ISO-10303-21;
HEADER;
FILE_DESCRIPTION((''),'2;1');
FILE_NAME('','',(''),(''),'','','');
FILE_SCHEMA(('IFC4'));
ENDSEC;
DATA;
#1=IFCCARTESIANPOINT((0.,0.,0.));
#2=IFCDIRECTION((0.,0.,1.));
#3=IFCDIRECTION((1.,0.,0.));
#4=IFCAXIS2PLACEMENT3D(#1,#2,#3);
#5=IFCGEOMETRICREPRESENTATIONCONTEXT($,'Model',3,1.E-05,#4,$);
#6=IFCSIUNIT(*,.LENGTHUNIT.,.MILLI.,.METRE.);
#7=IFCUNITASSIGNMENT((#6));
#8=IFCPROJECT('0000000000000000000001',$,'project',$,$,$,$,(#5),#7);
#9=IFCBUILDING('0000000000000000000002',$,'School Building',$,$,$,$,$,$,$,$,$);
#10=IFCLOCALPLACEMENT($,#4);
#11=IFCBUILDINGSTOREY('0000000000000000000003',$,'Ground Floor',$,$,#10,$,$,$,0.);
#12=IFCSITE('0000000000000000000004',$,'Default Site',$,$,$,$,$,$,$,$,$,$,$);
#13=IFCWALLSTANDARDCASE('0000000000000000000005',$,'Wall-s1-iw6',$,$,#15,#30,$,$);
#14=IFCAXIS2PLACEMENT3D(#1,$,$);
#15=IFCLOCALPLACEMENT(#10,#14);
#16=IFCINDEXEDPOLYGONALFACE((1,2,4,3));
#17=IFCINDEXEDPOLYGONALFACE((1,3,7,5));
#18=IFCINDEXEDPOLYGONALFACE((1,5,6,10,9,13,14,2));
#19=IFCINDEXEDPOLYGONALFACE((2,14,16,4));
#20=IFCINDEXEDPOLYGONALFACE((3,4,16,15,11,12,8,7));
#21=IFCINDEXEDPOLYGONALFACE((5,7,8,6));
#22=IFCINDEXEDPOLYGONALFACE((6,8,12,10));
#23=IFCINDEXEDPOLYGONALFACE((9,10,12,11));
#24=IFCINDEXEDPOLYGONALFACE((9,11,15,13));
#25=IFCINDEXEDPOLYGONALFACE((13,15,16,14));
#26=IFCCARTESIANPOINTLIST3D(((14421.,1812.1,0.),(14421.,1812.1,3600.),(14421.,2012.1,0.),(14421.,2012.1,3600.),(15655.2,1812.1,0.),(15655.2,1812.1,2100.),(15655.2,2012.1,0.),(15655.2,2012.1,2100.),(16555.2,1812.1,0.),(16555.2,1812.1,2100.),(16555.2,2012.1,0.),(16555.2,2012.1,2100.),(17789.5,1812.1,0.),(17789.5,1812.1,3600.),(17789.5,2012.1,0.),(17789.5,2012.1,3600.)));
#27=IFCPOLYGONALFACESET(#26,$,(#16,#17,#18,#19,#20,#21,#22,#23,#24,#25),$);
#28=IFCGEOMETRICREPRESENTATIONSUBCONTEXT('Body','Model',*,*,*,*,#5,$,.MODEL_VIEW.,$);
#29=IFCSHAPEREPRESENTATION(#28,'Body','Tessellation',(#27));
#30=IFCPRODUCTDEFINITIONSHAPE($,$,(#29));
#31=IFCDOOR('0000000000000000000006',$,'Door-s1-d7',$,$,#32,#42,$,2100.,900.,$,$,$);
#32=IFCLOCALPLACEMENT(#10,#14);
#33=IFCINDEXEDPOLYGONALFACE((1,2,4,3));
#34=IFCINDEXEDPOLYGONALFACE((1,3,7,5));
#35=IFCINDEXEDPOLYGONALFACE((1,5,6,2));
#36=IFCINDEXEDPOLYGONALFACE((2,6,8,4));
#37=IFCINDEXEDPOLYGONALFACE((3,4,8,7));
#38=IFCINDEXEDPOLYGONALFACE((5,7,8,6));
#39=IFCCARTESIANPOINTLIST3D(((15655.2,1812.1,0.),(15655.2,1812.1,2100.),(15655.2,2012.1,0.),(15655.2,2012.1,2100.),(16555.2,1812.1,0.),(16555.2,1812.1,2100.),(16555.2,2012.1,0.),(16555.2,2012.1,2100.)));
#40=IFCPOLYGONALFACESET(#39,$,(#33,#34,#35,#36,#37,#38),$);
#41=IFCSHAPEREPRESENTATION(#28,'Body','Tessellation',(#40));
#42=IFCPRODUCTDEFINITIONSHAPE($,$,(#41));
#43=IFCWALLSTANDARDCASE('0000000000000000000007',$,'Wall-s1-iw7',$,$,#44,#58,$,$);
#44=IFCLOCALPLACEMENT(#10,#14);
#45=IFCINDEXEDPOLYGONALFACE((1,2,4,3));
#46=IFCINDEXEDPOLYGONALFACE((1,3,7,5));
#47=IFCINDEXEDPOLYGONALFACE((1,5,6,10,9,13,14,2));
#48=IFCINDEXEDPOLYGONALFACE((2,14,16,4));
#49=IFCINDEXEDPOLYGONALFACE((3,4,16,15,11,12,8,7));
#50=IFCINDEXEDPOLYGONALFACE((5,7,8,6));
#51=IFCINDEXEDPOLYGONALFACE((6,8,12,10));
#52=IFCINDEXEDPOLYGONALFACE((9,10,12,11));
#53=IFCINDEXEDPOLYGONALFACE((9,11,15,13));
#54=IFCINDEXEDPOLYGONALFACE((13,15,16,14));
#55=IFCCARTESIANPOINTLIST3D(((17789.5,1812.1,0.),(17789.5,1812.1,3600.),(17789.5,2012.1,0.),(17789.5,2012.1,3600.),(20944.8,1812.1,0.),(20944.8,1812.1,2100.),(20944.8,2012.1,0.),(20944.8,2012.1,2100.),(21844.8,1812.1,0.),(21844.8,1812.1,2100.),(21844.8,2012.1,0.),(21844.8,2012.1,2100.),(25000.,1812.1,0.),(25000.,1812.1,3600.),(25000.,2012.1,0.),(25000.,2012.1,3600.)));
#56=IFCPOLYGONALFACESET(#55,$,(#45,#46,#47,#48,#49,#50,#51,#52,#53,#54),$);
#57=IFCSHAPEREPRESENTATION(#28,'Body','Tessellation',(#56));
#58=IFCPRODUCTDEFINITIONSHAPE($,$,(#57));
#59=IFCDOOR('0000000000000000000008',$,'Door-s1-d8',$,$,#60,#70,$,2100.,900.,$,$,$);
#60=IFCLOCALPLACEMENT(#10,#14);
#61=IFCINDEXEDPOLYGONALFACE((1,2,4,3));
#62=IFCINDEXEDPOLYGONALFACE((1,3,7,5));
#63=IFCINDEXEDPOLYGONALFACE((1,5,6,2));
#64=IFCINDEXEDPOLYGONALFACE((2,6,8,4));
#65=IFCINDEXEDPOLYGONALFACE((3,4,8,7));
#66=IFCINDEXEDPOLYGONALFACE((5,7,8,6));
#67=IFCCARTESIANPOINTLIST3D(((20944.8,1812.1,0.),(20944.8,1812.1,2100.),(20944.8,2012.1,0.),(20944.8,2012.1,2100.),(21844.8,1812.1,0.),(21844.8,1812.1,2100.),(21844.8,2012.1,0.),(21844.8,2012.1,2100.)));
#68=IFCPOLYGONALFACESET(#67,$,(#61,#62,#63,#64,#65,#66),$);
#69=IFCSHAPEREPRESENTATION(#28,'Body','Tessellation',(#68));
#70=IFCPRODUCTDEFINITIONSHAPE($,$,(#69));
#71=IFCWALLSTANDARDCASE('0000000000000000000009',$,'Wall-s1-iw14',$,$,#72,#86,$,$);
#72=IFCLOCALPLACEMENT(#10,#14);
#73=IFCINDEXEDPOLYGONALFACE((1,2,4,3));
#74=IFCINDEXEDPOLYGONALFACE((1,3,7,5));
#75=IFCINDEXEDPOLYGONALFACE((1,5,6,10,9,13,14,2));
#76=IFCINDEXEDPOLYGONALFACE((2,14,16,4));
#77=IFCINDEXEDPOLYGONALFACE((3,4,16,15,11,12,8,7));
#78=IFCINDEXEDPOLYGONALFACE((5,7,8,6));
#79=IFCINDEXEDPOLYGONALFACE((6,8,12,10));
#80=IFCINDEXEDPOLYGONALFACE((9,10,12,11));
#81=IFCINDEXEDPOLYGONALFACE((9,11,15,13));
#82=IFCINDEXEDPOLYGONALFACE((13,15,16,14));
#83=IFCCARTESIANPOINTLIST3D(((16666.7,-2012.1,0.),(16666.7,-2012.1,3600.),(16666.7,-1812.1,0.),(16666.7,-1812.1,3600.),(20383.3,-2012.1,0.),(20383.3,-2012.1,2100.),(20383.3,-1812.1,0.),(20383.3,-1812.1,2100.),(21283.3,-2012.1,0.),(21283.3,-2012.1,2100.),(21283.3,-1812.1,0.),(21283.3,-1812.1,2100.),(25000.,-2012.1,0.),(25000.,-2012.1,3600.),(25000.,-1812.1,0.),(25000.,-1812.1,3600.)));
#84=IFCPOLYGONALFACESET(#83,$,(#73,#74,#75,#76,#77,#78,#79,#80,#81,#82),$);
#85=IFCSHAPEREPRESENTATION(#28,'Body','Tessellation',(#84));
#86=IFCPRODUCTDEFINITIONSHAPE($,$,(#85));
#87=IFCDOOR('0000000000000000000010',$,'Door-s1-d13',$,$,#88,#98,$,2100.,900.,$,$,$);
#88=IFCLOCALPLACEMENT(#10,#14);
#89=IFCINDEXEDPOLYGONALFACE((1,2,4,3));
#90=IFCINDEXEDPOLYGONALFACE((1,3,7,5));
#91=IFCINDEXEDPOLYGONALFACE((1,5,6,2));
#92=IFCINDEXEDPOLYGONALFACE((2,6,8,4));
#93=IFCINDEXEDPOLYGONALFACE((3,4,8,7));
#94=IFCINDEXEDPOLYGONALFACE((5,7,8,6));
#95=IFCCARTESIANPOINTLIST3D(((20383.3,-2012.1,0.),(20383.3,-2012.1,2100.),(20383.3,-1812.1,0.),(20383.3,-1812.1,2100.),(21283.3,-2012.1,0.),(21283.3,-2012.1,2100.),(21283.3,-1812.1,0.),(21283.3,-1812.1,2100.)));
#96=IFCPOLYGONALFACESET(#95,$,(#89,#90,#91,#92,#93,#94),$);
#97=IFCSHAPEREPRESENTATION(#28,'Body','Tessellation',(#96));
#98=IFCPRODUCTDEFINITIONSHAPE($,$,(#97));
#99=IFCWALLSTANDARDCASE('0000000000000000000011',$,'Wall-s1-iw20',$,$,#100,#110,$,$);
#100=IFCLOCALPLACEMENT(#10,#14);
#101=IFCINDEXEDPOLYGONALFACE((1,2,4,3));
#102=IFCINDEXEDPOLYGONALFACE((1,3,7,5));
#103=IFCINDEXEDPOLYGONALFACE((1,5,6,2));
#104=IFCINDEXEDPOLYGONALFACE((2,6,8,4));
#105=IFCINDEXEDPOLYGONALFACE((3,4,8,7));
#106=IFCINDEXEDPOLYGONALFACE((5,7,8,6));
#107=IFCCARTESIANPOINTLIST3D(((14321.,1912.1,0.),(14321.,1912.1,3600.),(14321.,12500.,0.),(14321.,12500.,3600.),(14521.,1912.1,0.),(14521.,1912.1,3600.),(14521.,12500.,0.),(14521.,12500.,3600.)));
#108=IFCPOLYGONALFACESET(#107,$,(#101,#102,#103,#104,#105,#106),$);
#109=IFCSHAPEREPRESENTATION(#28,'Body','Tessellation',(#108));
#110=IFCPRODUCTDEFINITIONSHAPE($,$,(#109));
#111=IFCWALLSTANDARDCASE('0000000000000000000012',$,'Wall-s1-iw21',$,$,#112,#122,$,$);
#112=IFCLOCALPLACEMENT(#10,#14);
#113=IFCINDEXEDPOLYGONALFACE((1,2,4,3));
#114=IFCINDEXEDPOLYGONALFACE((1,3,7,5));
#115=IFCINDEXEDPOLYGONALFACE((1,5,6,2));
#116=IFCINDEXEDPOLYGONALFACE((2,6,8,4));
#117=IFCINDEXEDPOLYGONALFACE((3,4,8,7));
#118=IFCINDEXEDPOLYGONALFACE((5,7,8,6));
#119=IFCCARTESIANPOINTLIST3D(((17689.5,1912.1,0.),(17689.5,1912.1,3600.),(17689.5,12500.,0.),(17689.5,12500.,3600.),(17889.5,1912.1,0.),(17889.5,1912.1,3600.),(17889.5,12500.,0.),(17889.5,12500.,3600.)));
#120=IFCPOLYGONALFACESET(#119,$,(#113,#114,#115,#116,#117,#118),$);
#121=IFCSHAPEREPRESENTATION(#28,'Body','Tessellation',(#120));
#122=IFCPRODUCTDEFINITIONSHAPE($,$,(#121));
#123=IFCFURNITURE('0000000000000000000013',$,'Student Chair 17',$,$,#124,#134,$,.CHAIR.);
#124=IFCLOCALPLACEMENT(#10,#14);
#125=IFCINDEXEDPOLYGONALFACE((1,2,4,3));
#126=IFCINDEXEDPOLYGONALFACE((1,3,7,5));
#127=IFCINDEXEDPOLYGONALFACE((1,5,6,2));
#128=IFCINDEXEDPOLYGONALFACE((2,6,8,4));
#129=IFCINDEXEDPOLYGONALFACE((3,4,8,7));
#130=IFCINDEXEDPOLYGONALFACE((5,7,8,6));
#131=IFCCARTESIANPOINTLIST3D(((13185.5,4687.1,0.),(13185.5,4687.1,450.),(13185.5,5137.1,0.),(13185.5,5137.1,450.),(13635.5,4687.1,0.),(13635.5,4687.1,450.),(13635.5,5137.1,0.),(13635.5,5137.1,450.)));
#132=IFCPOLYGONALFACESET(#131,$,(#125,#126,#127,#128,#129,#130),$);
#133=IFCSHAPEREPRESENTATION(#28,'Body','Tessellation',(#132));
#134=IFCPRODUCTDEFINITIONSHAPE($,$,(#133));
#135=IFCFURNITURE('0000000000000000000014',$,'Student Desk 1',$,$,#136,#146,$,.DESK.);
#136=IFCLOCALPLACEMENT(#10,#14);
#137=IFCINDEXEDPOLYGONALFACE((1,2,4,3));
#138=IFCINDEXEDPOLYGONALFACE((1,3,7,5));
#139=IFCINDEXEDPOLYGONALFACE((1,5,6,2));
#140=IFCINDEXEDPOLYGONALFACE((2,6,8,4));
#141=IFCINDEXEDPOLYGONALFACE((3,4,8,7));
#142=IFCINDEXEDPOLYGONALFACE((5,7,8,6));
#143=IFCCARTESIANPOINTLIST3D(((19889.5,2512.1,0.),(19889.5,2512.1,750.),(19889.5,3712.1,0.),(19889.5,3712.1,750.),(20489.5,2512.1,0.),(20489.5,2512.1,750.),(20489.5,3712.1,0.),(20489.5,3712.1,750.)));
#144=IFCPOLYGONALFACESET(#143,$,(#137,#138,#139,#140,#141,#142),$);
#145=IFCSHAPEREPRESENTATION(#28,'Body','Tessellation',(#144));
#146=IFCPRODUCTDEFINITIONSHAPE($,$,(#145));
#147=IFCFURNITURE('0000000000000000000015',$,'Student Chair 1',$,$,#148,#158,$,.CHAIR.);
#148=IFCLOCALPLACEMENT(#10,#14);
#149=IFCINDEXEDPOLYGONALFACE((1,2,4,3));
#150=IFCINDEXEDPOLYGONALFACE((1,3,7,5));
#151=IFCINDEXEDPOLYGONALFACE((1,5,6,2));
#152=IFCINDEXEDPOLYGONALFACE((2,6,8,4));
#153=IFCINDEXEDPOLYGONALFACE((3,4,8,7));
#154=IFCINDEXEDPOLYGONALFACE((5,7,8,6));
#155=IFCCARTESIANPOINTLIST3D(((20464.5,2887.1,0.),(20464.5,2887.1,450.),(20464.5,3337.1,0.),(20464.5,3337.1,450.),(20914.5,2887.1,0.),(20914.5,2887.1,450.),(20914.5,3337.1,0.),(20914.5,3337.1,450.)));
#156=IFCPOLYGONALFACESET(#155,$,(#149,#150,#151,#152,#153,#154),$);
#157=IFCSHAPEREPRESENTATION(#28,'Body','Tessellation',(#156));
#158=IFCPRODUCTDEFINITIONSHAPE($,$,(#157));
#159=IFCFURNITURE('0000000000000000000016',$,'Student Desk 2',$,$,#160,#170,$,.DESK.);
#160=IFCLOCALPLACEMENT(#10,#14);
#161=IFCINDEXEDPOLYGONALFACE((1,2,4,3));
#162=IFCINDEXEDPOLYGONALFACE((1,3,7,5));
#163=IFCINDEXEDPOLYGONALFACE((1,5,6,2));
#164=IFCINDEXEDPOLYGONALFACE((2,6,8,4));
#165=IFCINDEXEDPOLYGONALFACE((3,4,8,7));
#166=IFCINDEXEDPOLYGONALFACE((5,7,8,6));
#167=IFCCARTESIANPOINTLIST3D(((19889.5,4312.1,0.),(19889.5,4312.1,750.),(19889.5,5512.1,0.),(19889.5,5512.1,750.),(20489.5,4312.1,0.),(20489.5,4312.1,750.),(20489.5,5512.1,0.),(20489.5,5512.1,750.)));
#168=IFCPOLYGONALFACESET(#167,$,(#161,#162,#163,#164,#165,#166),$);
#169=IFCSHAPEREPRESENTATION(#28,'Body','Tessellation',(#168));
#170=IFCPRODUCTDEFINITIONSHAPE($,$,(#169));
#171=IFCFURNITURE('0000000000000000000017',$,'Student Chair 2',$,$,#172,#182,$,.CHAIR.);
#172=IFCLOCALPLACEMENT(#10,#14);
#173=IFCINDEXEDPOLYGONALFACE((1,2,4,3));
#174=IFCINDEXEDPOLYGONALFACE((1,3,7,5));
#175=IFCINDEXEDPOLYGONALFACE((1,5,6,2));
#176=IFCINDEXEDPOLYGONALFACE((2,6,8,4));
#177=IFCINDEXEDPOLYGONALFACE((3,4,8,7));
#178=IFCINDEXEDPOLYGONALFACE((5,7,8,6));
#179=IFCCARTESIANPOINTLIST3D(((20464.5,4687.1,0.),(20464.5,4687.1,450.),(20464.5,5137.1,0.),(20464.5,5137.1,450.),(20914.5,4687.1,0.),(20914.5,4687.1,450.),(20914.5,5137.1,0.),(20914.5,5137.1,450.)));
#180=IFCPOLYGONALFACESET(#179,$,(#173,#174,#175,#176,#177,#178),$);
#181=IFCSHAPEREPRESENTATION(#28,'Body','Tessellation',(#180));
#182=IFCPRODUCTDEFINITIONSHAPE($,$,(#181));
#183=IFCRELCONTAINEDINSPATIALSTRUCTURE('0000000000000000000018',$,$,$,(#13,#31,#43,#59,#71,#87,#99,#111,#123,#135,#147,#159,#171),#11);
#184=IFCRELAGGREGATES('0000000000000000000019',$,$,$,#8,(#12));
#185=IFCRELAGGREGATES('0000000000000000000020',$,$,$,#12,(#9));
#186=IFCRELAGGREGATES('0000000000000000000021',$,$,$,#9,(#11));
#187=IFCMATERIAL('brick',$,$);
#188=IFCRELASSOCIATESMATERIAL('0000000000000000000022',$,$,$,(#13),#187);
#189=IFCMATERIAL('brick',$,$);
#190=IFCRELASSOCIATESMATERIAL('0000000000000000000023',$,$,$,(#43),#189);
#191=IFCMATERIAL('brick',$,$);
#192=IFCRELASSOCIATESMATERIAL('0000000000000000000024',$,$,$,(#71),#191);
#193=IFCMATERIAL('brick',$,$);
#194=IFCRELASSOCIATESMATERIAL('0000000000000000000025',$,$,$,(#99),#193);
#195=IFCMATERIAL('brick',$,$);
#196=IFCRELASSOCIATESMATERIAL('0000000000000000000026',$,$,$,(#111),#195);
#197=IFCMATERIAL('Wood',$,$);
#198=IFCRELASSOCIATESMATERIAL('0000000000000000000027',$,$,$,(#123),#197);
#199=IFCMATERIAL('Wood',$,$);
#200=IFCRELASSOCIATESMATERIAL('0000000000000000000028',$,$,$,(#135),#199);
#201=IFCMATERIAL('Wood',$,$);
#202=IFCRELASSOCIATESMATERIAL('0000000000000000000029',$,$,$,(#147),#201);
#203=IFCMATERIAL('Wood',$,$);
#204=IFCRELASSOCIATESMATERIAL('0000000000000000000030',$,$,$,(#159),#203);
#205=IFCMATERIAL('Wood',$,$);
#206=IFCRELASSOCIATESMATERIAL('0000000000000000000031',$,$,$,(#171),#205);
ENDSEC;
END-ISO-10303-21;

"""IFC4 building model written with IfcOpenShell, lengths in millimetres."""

from ifc_helpers import new_model, si_unit, frame, frame_2d, origin_with_axes, origin_2d, place, context, subcontext, project, spatial, rectangle, extrude, material, element, fill, save


model = new_model("IFC4")

# Units and contexts
model_context = context("Model", 3, precision=1e-05, world=origin_with_axes())
body_context = subcontext(model_context, "Body", "Model", "MODEL_VIEW")
ifc_project = project(units=[si_unit("LENGTHUNIT", "METRE", prefix="MILLI")], contexts=[model_context])

# Site, building, storey
site = spatial("IfcSite", under=ifc_project, Name="Default Site")
building = spatial("IfcBuilding", under=site, Name="School Building")
storey_placement = place(None, origin_with_axes())
storey = spatial("IfcBuildingStorey", under=building, at=storey_placement, Name="Ground Floor", Elevation=0.0)

# Walls, openings, doors
ifc_material_1 = material(Name="brick")
wall_1_placement = place(storey_placement, frame((14421.0, 1912.1, 0.0), z_axis=(0.0, 0.0, 1.0), x_axis=(1.0, 0.0, 0.0)))
wall_1 = element("IfcWallStandardCase", 1, at=wall_1_placement, inside=storey, material=ifc_material_1, Name="Wall-s1-iw6", context=body_context, shape_type="SweptSolid", body=[
    extrude(rectangle(XDim=3368.6, YDim=200.0, at=frame_2d((1684.3, 0.0))), origin_with_axes(), (0.0, 0.0, 1.0), 3600.0),
])
opening_1_placement = place(wall_1_placement, frame((1234.3, 0.0, 0.0), z_axis=(0.0, 0.0, 1.0), x_axis=(1.0, 0.0, 0.0)))
opening_1 = element("IfcOpeningElement", 2, at=opening_1_placement, cuts=wall_1, context=body_context, shape_type="SweptSolid", body=[
    extrude(rectangle(XDim=900.0, YDim=400.0, at=frame_2d((450.0, 0.0))), origin_with_axes(), (0.0, 0.0, 1.0), 2100.0),
])
door_1_placement = place(storey_placement, frame((15655.2, 1912.1, 0.0), z_axis=(0.0, 0.0, 1.0), x_axis=(1.0, 0.0, 0.0)))
door_1 = element("IfcDoor", 3, at=door_1_placement, inside=storey, Name="Door-s1-d7", OverallHeight=2100.0, OverallWidth=900.0, context=body_context, shape_type="SweptSolid", body=[
    extrude(rectangle(XDim=900.0, YDim=200.0, at=frame_2d((450.0, 0.0))), origin_with_axes(), (0.0, 0.0, 1.0), 2100.0),
])
fill(opening_1, door_1)
ifc_material_2 = material(Name="brick")
wall_2_placement = place(storey_placement, frame((17789.5, 1912.1, 0.0), z_axis=(0.0, 0.0, 1.0), x_axis=(1.0, 0.0, 0.0)))
wall_2 = element("IfcWallStandardCase", 4, at=wall_2_placement, inside=storey, material=ifc_material_2, Name="Wall-s1-iw7", context=body_context, shape_type="SweptSolid", body=[
    extrude(rectangle(XDim=7210.5, YDim=200.0, at=frame_2d((3605.2, 0.0))), origin_with_axes(), (0.0, 0.0, 1.0), 3600.0),
])
opening_2_placement = place(wall_2_placement, frame((3155.2, 0.0, 0.0), z_axis=(0.0, 0.0, 1.0), x_axis=(1.0, 0.0, 0.0)))
opening_2 = element("IfcOpeningElement", 5, at=opening_2_placement, cuts=wall_2, context=body_context, shape_type="SweptSolid", body=[
    extrude(rectangle(XDim=900.0, YDim=400.0, at=frame_2d((450.0, 0.0))), origin_with_axes(), (0.0, 0.0, 1.0), 2100.0),
])
door_2_placement = place(storey_placement, frame((20944.8, 1912.1, 0.0), z_axis=(0.0, 0.0, 1.0), x_axis=(1.0, 0.0, 0.0)))
door_2 = element("IfcDoor", 6, at=door_2_placement, inside=storey, Name="Door-s1-d8", OverallHeight=2100.0, OverallWidth=900.0, context=body_context, shape_type="SweptSolid", body=[
    extrude(rectangle(XDim=900.0, YDim=200.0, at=frame_2d((450.0, 0.0))), origin_with_axes(), (0.0, 0.0, 1.0), 2100.0),
])
fill(opening_2, door_2)
ifc_material_3 = material(Name="brick")
wall_3_placement = place(storey_placement, frame((16666.7, -1912.1, 0.0), z_axis=(0.0, 0.0, 1.0), x_axis=(1.0, 0.0, 0.0)))
wall_3 = element("IfcWallStandardCase", 7, at=wall_3_placement, inside=storey, material=ifc_material_3, Name="Wall-s1-iw14", context=body_context, shape_type="SweptSolid", body=[
    extrude(rectangle(XDim=8333.3, YDim=200.0, at=frame_2d((4166.7, 0.0))), origin_with_axes(), (0.0, 0.0, 1.0), 3600.0),
])
opening_3_placement = place(wall_3_placement, frame((3716.7, 0.0, 0.0), z_axis=(0.0, 0.0, 1.0), x_axis=(1.0, 0.0, 0.0)))
opening_3 = element("IfcOpeningElement", 8, at=opening_3_placement, cuts=wall_3, context=body_context, shape_type="SweptSolid", body=[
    extrude(rectangle(XDim=900.0, YDim=400.0, at=frame_2d((450.0, 0.0))), origin_with_axes(), (0.0, 0.0, 1.0), 2100.0),
])
door_3_placement = place(storey_placement, frame((20383.3, -1912.1, 0.0), z_axis=(0.0, 0.0, 1.0), x_axis=(1.0, 0.0, 0.0)))
door_3 = element("IfcDoor", 9, at=door_3_placement, inside=storey, Name="Door-s1-d13", OverallHeight=2100.0, OverallWidth=900.0, context=body_context, shape_type="SweptSolid", body=[
    extrude(rectangle(XDim=900.0, YDim=200.0, at=frame_2d((450.0, 0.0))), origin_with_axes(), (0.0, 0.0, 1.0), 2100.0),
])
fill(opening_3, door_3)

# Walls
ifc_material_4 = material(Name="brick")
wall_4_placement = place(storey_placement, frame((14421.0, 1912.1, 0.0), z_axis=(0.0, 0.0, 1.0), x_axis=(0.0, 1.0, 0.0)))
element("IfcWallStandardCase", 10, at=wall_4_placement, inside=storey, material=ifc_material_4, Name="Wall-s1-iw20", context=body_context, shape_type="SweptSolid", body=[
    extrude(rectangle(XDim=10587.9, YDim=200.0, at=frame_2d((5293.9, 0.0))), origin_with_axes(), (0.0, 0.0, 1.0), 3600.0),
])
ifc_material_5 = material(Name="brick")
wall_5_placement = place(storey_placement, frame((17789.5, 1912.1, 0.0), z_axis=(0.0, 0.0, 1.0), x_axis=(0.0, 1.0, 0.0)))
element("IfcWallStandardCase", 11, at=wall_5_placement, inside=storey, material=ifc_material_5, Name="Wall-s1-iw21", context=body_context, shape_type="SweptSolid", body=[
    extrude(rectangle(XDim=10587.9, YDim=200.0, at=frame_2d((5293.9, 0.0))), origin_with_axes(), (0.0, 0.0, 1.0), 3600.0),
])

# Furniture
ifc_material_6 = material(Name="Wood")
furniture_1_placement = place(storey_placement, frame((13410.5, 4912.1, 0.0), z_axis=(0.0, 0.0, 1.0), x_axis=(1.0, 0.0, 0.0)))
element("IfcFurniture", 12, at=furniture_1_placement, inside=storey, material=ifc_material_6, Name="Student Chair 17", PredefinedType="CHAIR", context=body_context, shape_type="SweptSolid", body=[
    extrude(rectangle(XDim=450.0, YDim=450.0, at=origin_2d()), origin_with_axes(), (0.0, 0.0, 1.0), 450.0),
])
ifc_material_7 = material(Name="Wood")
furniture_2_placement = place(storey_placement, frame((20189.5, 3112.1, 0.0), z_axis=(0.0, 0.0, 1.0), x_axis=(0.0, 1.0, 0.0)))
element("IfcFurniture", 13, at=furniture_2_placement, inside=storey, material=ifc_material_7, Name="Student Desk 1", PredefinedType="DESK", context=body_context, shape_type="SweptSolid", body=[
    extrude(rectangle(XDim=1200.0, YDim=600.0, at=origin_2d()), origin_with_axes(), (0.0, 0.0, 1.0), 750.0),
])
ifc_material_8 = material(Name="Wood")
furniture_3_placement = place(storey_placement, frame((20689.5, 3112.1, 0.0), z_axis=(0.0, 0.0, 1.0), x_axis=(1.0, 0.0, 0.0)))
element("IfcFurniture", 14, at=furniture_3_placement, inside=storey, material=ifc_material_8, Name="Student Chair 1", PredefinedType="CHAIR", context=body_context, shape_type="SweptSolid", body=[
    extrude(rectangle(XDim=450.0, YDim=450.0, at=origin_2d()), origin_with_axes(), (0.0, 0.0, 1.0), 450.0),
])
ifc_material_9 = material(Name="Wood")
furniture_4_placement = place(storey_placement, frame((20189.5, 4912.1, 0.0), z_axis=(0.0, 0.0, 1.0), x_axis=(0.0, 1.0, 0.0)))
element("IfcFurniture", 15, at=furniture_4_placement, inside=storey, material=ifc_material_9, Name="Student Desk 2", PredefinedType="DESK", context=body_context, shape_type="SweptSolid", body=[
    extrude(rectangle(XDim=1200.0, YDim=600.0, at=origin_2d()), origin_with_axes(), (0.0, 0.0, 1.0), 750.0),
])
ifc_material_10 = material(Name="Wood")
furniture_5_placement = place(storey_placement, frame((20689.5, 4912.1, 0.0), z_axis=(0.0, 0.0, 1.0), x_axis=(1.0, 0.0, 0.0)))
element("IfcFurniture", 16, at=furniture_5_placement, inside=storey, material=ifc_material_10, Name="Student Chair 2", PredefinedType="CHAIR", context=body_context, shape_type="SweptSolid", body=[
    extrude(rectangle(XDim=450.0, YDim=450.0, at=origin_2d()), origin_with_axes(), (0.0, 0.0, 1.0), 450.0),
])

save(model, "model.ifc")
